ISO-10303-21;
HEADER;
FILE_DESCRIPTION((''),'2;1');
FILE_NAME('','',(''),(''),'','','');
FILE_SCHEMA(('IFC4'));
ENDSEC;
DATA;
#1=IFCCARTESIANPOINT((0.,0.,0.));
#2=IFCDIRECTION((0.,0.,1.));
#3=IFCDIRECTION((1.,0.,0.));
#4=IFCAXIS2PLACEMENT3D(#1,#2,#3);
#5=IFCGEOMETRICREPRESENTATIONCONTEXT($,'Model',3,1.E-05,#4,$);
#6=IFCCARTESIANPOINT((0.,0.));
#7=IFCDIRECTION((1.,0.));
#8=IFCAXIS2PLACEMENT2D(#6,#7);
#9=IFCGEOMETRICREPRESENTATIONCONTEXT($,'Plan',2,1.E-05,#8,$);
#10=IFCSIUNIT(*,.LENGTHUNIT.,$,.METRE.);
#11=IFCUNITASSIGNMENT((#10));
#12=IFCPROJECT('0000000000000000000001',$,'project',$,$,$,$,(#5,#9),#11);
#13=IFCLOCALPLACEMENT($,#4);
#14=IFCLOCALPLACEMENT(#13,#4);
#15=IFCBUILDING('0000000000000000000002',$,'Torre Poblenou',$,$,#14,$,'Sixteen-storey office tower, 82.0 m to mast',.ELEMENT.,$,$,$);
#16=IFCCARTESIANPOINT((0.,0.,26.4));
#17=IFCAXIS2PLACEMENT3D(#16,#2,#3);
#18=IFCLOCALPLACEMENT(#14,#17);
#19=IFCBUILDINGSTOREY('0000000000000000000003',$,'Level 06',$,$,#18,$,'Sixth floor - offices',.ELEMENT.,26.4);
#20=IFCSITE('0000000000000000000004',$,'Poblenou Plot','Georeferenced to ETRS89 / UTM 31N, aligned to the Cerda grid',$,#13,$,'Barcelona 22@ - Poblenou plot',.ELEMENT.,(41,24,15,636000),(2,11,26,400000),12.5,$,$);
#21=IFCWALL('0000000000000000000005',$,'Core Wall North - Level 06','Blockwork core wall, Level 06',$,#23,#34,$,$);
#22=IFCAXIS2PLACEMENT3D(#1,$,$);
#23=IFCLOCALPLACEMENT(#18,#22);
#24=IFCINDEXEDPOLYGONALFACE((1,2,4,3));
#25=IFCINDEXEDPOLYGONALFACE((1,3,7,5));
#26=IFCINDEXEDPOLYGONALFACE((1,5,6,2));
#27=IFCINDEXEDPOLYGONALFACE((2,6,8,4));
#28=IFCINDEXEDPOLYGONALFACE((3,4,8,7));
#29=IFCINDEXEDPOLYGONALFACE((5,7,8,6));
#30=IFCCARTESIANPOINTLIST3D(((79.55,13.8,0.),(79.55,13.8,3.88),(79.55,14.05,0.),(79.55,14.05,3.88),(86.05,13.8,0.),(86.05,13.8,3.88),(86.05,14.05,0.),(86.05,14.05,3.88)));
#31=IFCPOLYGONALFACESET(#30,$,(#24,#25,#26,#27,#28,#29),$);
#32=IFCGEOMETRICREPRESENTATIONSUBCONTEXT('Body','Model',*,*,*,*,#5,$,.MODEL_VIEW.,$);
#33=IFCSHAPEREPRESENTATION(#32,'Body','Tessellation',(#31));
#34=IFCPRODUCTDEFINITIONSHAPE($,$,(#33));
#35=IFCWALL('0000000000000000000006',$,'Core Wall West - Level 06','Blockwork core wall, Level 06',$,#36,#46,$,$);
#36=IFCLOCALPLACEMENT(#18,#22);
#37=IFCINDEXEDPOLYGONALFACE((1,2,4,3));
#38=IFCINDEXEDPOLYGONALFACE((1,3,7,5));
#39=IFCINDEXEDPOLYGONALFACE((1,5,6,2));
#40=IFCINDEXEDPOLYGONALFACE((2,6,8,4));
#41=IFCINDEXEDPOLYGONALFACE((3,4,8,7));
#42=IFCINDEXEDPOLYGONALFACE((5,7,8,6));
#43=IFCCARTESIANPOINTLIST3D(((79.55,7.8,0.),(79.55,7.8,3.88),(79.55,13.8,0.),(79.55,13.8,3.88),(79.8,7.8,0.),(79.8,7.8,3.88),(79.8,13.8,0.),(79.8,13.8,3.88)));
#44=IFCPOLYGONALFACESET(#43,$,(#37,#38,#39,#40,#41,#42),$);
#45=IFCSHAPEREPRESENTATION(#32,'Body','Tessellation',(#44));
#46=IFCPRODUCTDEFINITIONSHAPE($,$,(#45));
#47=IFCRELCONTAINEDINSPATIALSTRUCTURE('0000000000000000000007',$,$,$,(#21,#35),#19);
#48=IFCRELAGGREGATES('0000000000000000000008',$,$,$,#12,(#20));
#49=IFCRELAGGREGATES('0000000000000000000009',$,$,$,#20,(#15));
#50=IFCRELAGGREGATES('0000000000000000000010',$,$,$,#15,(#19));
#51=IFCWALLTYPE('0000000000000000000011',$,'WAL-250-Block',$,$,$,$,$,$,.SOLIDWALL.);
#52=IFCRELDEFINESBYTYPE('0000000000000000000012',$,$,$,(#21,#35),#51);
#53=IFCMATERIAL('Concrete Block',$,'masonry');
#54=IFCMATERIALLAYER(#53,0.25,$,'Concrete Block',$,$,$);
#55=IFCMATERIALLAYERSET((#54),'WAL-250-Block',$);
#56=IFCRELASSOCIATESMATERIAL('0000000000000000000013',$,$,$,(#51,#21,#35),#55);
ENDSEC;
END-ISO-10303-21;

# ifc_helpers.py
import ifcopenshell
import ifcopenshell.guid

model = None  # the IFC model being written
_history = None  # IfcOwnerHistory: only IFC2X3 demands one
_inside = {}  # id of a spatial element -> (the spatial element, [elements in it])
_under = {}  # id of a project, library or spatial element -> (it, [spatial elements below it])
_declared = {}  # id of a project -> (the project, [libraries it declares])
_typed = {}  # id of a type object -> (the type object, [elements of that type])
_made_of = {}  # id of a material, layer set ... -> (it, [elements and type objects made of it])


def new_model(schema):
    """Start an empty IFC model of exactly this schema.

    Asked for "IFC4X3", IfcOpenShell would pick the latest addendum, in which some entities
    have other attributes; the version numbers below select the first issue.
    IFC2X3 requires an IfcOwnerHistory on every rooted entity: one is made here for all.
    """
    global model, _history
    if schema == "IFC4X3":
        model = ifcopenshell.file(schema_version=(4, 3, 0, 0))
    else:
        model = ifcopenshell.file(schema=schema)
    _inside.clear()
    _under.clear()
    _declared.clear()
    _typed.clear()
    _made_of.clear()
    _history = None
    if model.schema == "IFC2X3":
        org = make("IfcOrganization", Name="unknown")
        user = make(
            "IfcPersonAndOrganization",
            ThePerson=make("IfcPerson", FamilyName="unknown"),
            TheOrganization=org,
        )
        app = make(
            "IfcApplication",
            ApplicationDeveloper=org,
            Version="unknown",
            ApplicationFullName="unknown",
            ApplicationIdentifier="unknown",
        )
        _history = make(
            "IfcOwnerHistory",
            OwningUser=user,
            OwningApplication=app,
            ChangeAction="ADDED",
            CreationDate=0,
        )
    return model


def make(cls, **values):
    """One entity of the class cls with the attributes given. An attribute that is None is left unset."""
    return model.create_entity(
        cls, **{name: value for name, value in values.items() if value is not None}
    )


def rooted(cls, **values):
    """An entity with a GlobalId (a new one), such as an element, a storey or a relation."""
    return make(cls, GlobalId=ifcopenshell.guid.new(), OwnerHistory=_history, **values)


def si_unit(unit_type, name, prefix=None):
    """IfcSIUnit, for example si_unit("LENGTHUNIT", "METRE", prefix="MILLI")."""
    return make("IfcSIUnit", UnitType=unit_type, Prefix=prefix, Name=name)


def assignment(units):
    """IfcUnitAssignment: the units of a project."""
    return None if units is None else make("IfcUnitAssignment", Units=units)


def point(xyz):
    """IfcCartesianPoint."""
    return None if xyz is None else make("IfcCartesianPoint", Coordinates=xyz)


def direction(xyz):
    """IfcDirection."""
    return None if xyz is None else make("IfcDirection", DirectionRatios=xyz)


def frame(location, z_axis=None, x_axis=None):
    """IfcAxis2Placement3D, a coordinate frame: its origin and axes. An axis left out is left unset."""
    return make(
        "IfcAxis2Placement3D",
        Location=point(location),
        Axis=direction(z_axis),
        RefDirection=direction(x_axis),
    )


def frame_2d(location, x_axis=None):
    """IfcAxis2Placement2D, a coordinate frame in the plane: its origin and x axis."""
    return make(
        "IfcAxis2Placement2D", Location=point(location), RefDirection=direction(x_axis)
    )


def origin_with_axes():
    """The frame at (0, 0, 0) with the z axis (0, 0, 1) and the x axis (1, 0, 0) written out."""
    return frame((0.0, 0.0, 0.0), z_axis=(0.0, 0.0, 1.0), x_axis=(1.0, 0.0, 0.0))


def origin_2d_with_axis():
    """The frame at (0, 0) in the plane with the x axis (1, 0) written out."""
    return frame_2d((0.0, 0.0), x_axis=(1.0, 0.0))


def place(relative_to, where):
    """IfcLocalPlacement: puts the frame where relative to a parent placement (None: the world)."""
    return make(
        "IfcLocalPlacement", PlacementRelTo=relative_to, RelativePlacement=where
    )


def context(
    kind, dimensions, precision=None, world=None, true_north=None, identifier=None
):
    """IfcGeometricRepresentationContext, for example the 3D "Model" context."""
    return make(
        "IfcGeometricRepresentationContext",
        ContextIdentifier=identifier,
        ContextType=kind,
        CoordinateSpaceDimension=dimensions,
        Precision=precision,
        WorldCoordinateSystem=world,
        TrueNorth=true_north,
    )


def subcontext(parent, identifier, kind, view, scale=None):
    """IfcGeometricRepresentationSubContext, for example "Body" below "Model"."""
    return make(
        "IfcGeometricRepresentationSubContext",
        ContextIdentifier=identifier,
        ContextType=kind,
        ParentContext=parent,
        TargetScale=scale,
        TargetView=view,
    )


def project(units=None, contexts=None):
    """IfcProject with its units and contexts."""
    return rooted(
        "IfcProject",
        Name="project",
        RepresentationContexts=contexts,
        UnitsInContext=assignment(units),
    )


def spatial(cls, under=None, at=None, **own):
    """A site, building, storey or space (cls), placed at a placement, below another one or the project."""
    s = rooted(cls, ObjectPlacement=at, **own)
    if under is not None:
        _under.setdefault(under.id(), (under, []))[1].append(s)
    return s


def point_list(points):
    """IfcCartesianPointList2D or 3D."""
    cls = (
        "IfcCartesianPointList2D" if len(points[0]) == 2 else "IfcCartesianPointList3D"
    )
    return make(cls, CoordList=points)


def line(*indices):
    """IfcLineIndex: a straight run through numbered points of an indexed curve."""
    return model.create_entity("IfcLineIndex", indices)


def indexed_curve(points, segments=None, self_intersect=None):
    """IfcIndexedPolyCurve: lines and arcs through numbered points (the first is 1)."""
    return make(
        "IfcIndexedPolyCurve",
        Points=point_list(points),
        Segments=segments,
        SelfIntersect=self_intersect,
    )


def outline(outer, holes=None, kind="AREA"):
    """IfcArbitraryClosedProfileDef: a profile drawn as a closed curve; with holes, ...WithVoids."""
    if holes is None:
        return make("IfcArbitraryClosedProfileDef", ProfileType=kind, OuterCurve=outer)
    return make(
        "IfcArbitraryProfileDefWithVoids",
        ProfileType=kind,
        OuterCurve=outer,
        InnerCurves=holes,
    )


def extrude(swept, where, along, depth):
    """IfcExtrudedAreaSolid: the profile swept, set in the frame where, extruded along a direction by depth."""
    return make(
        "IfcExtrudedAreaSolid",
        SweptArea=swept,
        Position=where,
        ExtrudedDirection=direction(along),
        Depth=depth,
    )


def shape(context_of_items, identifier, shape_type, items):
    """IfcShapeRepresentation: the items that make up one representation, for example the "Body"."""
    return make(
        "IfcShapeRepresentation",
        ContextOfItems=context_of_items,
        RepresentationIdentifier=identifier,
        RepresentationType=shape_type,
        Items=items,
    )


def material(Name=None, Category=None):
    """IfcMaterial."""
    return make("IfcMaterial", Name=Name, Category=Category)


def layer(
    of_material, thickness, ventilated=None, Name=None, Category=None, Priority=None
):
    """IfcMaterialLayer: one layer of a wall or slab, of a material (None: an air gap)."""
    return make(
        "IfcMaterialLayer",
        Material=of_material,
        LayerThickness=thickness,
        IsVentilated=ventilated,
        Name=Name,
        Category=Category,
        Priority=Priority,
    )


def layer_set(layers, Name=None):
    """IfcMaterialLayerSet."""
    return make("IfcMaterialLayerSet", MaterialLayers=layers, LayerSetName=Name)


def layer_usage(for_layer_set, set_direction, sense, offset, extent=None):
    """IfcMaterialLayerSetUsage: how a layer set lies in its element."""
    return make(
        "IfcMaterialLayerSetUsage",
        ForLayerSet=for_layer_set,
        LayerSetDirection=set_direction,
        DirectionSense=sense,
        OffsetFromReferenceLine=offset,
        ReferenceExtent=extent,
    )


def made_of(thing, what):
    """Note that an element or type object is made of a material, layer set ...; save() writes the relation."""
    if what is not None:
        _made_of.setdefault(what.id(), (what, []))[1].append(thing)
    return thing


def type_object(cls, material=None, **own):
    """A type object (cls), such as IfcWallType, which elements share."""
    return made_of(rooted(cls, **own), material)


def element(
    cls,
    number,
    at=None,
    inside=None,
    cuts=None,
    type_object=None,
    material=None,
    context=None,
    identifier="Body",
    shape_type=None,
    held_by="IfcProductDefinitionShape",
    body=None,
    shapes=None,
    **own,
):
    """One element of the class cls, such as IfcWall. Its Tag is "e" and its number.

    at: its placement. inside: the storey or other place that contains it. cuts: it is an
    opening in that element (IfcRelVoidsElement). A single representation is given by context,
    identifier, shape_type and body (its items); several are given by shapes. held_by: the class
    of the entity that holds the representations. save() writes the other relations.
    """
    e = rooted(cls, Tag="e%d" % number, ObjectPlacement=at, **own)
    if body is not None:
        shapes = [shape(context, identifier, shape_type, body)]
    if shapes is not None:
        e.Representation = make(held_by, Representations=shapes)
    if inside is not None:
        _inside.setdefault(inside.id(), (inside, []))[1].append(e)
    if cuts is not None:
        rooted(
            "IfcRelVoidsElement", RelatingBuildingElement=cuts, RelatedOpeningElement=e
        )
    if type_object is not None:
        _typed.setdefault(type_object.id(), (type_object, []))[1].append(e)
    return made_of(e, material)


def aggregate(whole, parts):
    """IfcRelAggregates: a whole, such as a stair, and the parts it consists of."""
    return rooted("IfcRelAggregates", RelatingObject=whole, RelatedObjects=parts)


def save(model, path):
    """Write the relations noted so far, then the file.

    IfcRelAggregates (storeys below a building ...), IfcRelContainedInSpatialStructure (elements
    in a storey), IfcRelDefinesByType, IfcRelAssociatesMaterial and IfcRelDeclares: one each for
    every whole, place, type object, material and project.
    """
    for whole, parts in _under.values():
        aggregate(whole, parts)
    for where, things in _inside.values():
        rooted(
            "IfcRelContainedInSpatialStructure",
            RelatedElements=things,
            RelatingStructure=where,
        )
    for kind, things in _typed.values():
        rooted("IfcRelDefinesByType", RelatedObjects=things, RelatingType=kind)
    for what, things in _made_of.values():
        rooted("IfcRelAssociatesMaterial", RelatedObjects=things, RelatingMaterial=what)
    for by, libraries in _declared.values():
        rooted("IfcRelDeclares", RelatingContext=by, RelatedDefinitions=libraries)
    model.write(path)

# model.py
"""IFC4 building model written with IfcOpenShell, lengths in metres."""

from ifc_helpers import new_model, si_unit, frame, origin_with_axes, origin_2d_with_axis, place, context, subcontext, project, spatial, line, indexed_curve, outline, extrude, material, layer, layer_set, layer_usage, type_object, element, save


model = new_model("IFC4")

# Units and contexts
model_context = context("Model", 3, precision=1e-05, world=origin_with_axes())
plan_context = context("Plan", 2, precision=1e-05, world=origin_2d_with_axis())
body_context = subcontext(model_context, "Body", "Model", "MODEL_VIEW")
ifc_project = project(units=[si_unit("LENGTHUNIT", "METRE")], contexts=[model_context, plan_context])

# Site, building, storey
site_placement = place(None, origin_with_axes())
site = spatial("IfcSite", under=ifc_project, at=site_placement, Name="Poblenou Plot", Description="Georeferenced to ETRS89 / UTM 31N, aligned to the Cerda grid", LongName="Barcelona 22@ - Poblenou plot", CompositionType="ELEMENT", RefLatitude=(41, 24, 15, 636000), RefLongitude=(2, 11, 26, 400000), RefElevation=12.5)
building_placement = place(site_placement, origin_with_axes())
building = spatial("IfcBuilding", under=site, at=building_placement, Name="Torre Poblenou", LongName="Sixteen-storey office tower, 82.0 m to mast", CompositionType="ELEMENT")
storey_placement = place(building_placement, frame((0.0, 0.0, 26.4), z_axis=(0.0, 0.0, 1.0), x_axis=(1.0, 0.0, 0.0)))
storey = spatial("IfcBuildingStorey", under=building, at=storey_placement, Name="Level 06", LongName="Sixth floor - offices", CompositionType="ELEMENT", Elevation=26.4)

# Walls
ifc_material_1 = material(Name="Concrete Block", Category="masonry")
ifc_layer_1 = layer(ifc_material_1, 0.25, Name="Concrete Block")
ifc_layer_set_1 = layer_set([ifc_layer_1], Name="WAL-250-Block")
ifc_layer_usage_1 = layer_usage(ifc_layer_set_1, "AXIS2", "POSITIVE", 0.0)
wall_type = type_object("IfcWallType", Name="WAL-250-Block", PredefinedType="SOLIDWALL", material=ifc_layer_set_1)
wall_1_placement = place(storey_placement, frame((79.55, 13.8, 0.0), z_axis=(0.0, 0.0, 1.0), x_axis=(1.0, 0.0, 0.0)))
element("IfcWall", 1, at=wall_1_placement, inside=storey, type_object=wall_type, material=ifc_layer_usage_1, Name="Core Wall North - Level 06", Description="Blockwork core wall, Level 06", context=body_context, shape_type="SweptSolid", body=[
    extrude(outline(indexed_curve([(0.0, 0.0), (6.5, 0.0), (6.5, 0.25), (0.0, 0.25)], segments=[line(1, 2, 3, 4, 1)])), origin_with_axes(), (0.0, 0.0, 1.0), 3.88),
])
ifc_layer_usage_2 = layer_usage(ifc_layer_set_1, "AXIS2", "POSITIVE", 0.0)
wall_2_placement = place(storey_placement, frame((79.8, 7.8, 0.0), z_axis=(0.0, 0.0, 1.0), x_axis=(0.0, 1.0, 0.0)))
element("IfcWall", 2, at=wall_2_placement, inside=storey, type_object=wall_type, material=ifc_layer_usage_2, Name="Core Wall West - Level 06", Description="Blockwork core wall, Level 06", context=body_context, shape_type="SweptSolid", body=[
    extrude(outline(indexed_curve([(0.0, 0.0), (6.0, 0.0), (6.0, 0.25), (0.0, 0.25)], segments=[line(1, 2, 3, 4, 1)])), origin_with_axes(), (0.0, 0.0, 1.0), 3.88),
])

save(model, "model.ifc")
